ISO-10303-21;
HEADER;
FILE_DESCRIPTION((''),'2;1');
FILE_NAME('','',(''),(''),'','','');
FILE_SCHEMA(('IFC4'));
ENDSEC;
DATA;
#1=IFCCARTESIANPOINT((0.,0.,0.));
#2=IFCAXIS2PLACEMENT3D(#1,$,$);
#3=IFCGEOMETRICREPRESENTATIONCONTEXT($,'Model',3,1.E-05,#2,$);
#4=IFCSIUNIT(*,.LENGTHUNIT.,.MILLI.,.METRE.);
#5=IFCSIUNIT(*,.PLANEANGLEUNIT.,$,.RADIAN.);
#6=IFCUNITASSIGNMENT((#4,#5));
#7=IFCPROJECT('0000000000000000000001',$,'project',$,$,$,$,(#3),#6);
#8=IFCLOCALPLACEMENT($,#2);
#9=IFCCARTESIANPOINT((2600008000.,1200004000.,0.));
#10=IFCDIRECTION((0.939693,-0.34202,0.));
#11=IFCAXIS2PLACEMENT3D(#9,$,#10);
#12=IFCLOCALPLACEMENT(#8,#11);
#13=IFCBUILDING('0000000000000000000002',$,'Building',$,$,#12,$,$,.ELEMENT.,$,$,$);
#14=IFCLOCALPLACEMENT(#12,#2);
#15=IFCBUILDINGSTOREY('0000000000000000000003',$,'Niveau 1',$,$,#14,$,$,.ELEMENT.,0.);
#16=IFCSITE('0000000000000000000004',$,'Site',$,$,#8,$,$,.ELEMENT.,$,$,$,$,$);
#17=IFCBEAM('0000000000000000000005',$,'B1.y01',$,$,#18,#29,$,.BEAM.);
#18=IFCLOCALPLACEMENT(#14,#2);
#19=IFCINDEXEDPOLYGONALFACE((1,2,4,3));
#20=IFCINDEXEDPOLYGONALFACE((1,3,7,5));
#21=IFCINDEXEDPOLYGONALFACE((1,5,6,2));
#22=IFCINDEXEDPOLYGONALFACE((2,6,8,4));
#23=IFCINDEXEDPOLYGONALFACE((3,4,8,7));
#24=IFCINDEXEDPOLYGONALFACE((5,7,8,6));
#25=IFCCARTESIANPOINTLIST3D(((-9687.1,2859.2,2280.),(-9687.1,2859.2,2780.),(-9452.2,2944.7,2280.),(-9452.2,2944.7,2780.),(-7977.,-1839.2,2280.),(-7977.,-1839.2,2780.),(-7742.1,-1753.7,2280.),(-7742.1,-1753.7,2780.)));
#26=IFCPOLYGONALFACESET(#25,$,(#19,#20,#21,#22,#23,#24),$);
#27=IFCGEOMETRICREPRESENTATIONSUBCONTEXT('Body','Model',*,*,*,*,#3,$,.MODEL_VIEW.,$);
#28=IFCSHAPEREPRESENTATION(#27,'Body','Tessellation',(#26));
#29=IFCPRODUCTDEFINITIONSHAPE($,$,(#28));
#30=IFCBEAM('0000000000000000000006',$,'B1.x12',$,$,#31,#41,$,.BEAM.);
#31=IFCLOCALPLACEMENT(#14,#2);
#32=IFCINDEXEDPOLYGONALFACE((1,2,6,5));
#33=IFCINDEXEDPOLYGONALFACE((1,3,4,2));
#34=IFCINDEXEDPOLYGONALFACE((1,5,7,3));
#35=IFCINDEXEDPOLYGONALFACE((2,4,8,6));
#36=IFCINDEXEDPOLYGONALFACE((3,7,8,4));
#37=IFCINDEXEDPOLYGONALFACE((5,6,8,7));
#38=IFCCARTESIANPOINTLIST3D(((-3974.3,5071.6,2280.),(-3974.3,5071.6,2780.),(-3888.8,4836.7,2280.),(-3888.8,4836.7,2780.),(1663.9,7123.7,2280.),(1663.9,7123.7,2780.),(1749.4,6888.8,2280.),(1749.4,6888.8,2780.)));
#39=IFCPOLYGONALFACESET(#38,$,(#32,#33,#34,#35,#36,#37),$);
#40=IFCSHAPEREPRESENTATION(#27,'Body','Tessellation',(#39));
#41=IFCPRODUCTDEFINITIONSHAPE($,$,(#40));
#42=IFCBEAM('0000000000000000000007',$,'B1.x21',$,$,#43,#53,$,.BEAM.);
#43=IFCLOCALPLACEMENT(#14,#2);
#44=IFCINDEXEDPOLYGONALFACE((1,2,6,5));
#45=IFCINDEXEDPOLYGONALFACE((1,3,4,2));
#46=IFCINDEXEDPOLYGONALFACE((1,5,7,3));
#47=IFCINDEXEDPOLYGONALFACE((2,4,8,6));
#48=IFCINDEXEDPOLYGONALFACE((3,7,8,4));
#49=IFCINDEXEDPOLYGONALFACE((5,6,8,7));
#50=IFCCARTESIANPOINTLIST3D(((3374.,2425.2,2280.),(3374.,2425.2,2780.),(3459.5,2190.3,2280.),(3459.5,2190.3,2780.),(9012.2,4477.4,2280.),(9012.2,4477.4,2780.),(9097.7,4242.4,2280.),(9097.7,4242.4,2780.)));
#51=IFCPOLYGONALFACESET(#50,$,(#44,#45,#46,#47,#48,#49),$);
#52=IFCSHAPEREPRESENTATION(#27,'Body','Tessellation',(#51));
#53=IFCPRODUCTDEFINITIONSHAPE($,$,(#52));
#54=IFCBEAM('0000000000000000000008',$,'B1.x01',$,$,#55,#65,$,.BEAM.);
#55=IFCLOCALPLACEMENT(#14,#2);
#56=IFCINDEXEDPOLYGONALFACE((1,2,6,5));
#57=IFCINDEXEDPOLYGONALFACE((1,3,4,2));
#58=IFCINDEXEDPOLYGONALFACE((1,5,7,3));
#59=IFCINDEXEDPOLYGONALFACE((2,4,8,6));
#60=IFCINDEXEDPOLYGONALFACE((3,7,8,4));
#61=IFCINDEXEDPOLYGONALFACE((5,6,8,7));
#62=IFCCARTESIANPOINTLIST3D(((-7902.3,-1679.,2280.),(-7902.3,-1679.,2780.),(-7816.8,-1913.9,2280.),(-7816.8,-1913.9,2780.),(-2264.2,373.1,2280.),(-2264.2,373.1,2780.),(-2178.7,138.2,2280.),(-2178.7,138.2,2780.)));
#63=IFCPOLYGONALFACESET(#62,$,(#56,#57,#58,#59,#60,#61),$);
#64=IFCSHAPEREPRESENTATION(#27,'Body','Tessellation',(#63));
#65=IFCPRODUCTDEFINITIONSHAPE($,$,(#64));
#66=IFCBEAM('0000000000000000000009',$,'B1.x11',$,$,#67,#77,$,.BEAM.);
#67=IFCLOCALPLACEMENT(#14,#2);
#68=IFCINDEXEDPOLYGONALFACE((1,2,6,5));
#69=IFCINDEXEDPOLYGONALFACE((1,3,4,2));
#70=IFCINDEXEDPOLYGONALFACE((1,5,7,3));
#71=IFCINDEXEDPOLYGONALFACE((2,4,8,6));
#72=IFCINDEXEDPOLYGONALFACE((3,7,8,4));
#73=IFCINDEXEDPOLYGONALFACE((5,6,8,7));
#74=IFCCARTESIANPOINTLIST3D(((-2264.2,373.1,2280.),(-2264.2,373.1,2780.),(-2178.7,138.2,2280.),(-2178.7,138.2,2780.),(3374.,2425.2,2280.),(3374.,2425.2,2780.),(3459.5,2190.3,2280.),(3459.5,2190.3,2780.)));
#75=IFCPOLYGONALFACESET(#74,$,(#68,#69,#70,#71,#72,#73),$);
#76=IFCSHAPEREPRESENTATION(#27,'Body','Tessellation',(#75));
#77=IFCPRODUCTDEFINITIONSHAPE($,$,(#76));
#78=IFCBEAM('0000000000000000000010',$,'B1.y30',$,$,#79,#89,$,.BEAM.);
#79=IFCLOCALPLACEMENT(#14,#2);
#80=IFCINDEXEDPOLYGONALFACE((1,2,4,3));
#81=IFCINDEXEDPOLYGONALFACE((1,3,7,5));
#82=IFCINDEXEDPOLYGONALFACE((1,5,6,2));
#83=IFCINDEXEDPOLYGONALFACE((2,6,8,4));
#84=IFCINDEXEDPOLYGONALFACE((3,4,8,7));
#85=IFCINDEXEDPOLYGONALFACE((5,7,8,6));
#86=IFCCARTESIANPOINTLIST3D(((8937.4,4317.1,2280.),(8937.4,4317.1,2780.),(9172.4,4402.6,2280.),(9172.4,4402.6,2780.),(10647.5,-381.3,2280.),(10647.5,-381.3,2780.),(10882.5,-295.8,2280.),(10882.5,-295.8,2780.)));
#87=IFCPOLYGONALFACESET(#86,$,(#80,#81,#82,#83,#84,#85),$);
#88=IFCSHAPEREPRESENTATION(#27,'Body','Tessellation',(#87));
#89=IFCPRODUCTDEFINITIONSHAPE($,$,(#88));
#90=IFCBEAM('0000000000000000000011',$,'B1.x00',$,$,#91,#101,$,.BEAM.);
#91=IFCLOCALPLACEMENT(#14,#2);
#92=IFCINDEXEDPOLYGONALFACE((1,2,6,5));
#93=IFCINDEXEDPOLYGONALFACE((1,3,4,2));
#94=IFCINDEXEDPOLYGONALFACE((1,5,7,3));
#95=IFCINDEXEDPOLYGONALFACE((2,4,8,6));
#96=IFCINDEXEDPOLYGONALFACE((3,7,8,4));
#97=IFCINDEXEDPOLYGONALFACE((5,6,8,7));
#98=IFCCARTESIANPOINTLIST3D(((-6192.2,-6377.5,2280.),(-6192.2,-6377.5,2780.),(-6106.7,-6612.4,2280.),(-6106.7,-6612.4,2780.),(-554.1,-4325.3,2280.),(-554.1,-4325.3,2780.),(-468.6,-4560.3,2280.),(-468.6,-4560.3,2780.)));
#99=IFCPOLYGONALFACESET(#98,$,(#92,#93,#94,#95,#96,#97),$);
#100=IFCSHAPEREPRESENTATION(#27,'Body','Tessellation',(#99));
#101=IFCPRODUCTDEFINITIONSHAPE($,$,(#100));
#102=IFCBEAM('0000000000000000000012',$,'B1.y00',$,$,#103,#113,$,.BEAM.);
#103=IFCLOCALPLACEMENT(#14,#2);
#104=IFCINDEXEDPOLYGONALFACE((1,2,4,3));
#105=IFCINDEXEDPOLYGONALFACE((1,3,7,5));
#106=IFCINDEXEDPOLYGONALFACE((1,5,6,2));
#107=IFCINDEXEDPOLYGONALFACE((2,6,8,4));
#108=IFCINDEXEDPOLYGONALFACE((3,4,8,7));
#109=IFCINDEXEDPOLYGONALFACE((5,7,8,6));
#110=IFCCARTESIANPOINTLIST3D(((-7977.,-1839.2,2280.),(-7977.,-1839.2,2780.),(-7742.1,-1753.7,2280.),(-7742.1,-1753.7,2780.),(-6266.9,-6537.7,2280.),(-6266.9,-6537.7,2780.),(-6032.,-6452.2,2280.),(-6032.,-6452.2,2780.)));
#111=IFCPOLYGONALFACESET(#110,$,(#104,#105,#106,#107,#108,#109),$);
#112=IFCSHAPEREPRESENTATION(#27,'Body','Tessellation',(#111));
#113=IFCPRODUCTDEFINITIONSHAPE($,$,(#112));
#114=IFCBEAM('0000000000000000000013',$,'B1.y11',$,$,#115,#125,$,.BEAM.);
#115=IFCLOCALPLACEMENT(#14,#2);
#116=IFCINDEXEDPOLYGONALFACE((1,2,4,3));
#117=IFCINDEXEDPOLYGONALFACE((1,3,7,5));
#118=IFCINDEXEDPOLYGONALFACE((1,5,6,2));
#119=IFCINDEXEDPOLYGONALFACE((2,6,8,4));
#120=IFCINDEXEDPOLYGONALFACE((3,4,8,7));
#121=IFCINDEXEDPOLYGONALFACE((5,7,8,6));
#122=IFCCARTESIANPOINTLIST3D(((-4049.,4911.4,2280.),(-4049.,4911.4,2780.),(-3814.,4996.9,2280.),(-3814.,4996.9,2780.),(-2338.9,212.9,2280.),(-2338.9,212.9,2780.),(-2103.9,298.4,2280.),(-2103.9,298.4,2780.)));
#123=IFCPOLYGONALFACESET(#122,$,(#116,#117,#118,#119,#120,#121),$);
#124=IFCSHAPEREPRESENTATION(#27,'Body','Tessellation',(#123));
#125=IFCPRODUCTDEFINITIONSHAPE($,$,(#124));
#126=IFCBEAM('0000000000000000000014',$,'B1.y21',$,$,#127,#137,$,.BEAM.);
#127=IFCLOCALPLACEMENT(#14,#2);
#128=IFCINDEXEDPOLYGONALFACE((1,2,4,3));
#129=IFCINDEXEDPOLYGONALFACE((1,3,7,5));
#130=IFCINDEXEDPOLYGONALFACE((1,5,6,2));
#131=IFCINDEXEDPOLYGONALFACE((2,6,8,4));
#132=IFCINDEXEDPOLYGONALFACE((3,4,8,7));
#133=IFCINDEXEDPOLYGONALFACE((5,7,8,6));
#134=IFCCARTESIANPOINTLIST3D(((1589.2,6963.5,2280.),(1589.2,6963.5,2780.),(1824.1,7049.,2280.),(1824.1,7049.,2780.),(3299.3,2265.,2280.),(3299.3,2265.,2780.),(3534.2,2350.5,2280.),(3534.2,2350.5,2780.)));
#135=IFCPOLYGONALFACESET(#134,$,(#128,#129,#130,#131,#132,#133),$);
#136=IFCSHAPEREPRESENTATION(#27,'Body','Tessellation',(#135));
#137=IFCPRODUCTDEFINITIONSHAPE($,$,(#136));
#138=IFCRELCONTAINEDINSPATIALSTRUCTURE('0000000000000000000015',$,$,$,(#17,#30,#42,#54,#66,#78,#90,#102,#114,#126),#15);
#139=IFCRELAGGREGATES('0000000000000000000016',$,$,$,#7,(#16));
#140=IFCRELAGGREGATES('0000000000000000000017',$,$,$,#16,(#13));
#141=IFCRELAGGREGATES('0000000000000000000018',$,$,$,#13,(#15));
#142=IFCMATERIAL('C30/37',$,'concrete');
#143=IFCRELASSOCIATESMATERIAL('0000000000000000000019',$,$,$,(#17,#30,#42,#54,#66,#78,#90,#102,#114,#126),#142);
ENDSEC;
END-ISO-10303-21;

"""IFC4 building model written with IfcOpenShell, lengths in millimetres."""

from ifc_helpers import new_model, si_unit, frame, origin, place, context, subcontext, project, spatial, rectangle, extrude, material, element, save


model = new_model("IFC4")

# Units and contexts
model_context = context("Model", 3, precision=1e-05, world=origin())
body_context = subcontext(model_context, "Body", "Model", "MODEL_VIEW")
ifc_project = project(units=[si_unit("LENGTHUNIT", "METRE", prefix="MILLI"), si_unit("PLANEANGLEUNIT", "RADIAN")], contexts=[model_context])

# Site, building, storey
site_placement = place(None, origin())
site = spatial("IfcSite", under=ifc_project, at=site_placement, Name="Site", CompositionType="ELEMENT")
building_placement = place(site_placement, frame((2600008000.0, 1200004000.0, 0.0), x_axis=(0.939693, -0.34202, 0.0)))
building = spatial("IfcBuilding", under=site, at=building_placement, Name="Building", CompositionType="ELEMENT")
storey_placement = place(building_placement, origin())
storey = spatial("IfcBuildingStorey", under=building, at=storey_placement, Name="Niveau 1", CompositionType="ELEMENT", Elevation=0.0)

# Shared definitions
ifc_material = material(Name="C30/37", Category="concrete")

# Beams
beam_1_placement = place(storey_placement, frame((-7859.6, -1796.5, 2530.0), z_axis=(-0.34202, 0.939693, 0.0), x_axis=(-0.939693, -0.34202, 0.0)))
element("IfcBeam", 1, at=beam_1_placement, inside=storey, material=ifc_material, Name="B1.y01", PredefinedType="BEAM", context=body_context, shape_type="SweptSolid", body=[
    extrude(rectangle(XDim=250.0, YDim=500.0), origin(), (0.0, 0.0, 1.0), 5000.0),
])
for number, where, z_axis, x_axis, name in (
    (2, (-3931.5, 4954.1, 2530.0), (0.939693, 0.34202, 0.0), (-0.34202, 0.939693, 0.0), "B1.x12"),
    (3, (3416.8, 2307.8, 2530.0), (0.939693, 0.34202, 0.0), (-0.34202, 0.939693, 0.0), "B1.x21"),
    (4, (-7859.6, -1796.5, 2530.0), (0.939693, 0.34202, 0.0), (-0.34202, 0.939693, 0.0), "B1.x01"),
    (5, (-2221.4, 255.7, 2530.0), (0.939693, 0.34202, 0.0), (-0.34202, 0.939693, 0.0), "B1.x11"),
):
    element("IfcBeam", number, at=place(storey_placement, frame(where, z_axis=z_axis, x_axis=x_axis)), inside=storey, material=ifc_material, Name=name, PredefinedType="BEAM", context=body_context, shape_type="SweptSolid", body=[
        extrude(rectangle(XDim=250.0, YDim=500.0), origin(), (0.0, 0.0, 1.0), 6000.0),
    ])
beam_2_placement = place(storey_placement, frame((10765.0, -338.6, 2530.0), z_axis=(-0.34202, 0.939693, 0.0), x_axis=(-0.939693, -0.34202, 0.0)))
element("IfcBeam", 6, at=beam_2_placement, inside=storey, material=ifc_material, Name="B1.y30", PredefinedType="BEAM", context=body_context, shape_type="SweptSolid", body=[
    extrude(rectangle(XDim=250.0, YDim=500.0), origin(), (0.0, 0.0, 1.0), 5000.0),
])
beam_3_placement = place(storey_placement, frame((-6149.5, -6494.9, 2530.0), z_axis=(0.939693, 0.34202, 0.0), x_axis=(-0.34202, 0.939693, 0.0)))
element("IfcBeam", 7, at=beam_3_placement, inside=storey, material=ifc_material, Name="B1.x00", PredefinedType="BEAM", context=body_context, shape_type="SweptSolid", body=[
    extrude(rectangle(XDim=250.0, YDim=500.0), origin(), (0.0, 0.0, 1.0), 6000.0),
])
for number, where, z_axis, x_axis, name in (
    (8, (-6149.5, -6494.9, 2530.0), (-0.34202, 0.939693, 0.0), (-0.939693, -0.34202, 0.0), "B1.y00"),
    (9, (-2221.4, 255.7, 2530.0), (-0.34202, 0.939693, 0.0), (-0.939693, -0.34202, 0.0), "B1.y11"),
    (10, (3416.8, 2307.8, 2530.0), (-0.34202, 0.939693, 0.0), (-0.939693, -0.34202, 0.0), "B1.y21"),
):
    element("IfcBeam", number, at=place(storey_placement, frame(where, z_axis=z_axis, x_axis=x_axis)), inside=storey, material=ifc_material, Name=name, PredefinedType="BEAM", context=body_context, shape_type="SweptSolid", body=[
        extrude(rectangle(XDim=250.0, YDim=500.0), origin(), (0.0, 0.0, 1.0), 5000.0),
    ])

save(model, "model.ifc")
